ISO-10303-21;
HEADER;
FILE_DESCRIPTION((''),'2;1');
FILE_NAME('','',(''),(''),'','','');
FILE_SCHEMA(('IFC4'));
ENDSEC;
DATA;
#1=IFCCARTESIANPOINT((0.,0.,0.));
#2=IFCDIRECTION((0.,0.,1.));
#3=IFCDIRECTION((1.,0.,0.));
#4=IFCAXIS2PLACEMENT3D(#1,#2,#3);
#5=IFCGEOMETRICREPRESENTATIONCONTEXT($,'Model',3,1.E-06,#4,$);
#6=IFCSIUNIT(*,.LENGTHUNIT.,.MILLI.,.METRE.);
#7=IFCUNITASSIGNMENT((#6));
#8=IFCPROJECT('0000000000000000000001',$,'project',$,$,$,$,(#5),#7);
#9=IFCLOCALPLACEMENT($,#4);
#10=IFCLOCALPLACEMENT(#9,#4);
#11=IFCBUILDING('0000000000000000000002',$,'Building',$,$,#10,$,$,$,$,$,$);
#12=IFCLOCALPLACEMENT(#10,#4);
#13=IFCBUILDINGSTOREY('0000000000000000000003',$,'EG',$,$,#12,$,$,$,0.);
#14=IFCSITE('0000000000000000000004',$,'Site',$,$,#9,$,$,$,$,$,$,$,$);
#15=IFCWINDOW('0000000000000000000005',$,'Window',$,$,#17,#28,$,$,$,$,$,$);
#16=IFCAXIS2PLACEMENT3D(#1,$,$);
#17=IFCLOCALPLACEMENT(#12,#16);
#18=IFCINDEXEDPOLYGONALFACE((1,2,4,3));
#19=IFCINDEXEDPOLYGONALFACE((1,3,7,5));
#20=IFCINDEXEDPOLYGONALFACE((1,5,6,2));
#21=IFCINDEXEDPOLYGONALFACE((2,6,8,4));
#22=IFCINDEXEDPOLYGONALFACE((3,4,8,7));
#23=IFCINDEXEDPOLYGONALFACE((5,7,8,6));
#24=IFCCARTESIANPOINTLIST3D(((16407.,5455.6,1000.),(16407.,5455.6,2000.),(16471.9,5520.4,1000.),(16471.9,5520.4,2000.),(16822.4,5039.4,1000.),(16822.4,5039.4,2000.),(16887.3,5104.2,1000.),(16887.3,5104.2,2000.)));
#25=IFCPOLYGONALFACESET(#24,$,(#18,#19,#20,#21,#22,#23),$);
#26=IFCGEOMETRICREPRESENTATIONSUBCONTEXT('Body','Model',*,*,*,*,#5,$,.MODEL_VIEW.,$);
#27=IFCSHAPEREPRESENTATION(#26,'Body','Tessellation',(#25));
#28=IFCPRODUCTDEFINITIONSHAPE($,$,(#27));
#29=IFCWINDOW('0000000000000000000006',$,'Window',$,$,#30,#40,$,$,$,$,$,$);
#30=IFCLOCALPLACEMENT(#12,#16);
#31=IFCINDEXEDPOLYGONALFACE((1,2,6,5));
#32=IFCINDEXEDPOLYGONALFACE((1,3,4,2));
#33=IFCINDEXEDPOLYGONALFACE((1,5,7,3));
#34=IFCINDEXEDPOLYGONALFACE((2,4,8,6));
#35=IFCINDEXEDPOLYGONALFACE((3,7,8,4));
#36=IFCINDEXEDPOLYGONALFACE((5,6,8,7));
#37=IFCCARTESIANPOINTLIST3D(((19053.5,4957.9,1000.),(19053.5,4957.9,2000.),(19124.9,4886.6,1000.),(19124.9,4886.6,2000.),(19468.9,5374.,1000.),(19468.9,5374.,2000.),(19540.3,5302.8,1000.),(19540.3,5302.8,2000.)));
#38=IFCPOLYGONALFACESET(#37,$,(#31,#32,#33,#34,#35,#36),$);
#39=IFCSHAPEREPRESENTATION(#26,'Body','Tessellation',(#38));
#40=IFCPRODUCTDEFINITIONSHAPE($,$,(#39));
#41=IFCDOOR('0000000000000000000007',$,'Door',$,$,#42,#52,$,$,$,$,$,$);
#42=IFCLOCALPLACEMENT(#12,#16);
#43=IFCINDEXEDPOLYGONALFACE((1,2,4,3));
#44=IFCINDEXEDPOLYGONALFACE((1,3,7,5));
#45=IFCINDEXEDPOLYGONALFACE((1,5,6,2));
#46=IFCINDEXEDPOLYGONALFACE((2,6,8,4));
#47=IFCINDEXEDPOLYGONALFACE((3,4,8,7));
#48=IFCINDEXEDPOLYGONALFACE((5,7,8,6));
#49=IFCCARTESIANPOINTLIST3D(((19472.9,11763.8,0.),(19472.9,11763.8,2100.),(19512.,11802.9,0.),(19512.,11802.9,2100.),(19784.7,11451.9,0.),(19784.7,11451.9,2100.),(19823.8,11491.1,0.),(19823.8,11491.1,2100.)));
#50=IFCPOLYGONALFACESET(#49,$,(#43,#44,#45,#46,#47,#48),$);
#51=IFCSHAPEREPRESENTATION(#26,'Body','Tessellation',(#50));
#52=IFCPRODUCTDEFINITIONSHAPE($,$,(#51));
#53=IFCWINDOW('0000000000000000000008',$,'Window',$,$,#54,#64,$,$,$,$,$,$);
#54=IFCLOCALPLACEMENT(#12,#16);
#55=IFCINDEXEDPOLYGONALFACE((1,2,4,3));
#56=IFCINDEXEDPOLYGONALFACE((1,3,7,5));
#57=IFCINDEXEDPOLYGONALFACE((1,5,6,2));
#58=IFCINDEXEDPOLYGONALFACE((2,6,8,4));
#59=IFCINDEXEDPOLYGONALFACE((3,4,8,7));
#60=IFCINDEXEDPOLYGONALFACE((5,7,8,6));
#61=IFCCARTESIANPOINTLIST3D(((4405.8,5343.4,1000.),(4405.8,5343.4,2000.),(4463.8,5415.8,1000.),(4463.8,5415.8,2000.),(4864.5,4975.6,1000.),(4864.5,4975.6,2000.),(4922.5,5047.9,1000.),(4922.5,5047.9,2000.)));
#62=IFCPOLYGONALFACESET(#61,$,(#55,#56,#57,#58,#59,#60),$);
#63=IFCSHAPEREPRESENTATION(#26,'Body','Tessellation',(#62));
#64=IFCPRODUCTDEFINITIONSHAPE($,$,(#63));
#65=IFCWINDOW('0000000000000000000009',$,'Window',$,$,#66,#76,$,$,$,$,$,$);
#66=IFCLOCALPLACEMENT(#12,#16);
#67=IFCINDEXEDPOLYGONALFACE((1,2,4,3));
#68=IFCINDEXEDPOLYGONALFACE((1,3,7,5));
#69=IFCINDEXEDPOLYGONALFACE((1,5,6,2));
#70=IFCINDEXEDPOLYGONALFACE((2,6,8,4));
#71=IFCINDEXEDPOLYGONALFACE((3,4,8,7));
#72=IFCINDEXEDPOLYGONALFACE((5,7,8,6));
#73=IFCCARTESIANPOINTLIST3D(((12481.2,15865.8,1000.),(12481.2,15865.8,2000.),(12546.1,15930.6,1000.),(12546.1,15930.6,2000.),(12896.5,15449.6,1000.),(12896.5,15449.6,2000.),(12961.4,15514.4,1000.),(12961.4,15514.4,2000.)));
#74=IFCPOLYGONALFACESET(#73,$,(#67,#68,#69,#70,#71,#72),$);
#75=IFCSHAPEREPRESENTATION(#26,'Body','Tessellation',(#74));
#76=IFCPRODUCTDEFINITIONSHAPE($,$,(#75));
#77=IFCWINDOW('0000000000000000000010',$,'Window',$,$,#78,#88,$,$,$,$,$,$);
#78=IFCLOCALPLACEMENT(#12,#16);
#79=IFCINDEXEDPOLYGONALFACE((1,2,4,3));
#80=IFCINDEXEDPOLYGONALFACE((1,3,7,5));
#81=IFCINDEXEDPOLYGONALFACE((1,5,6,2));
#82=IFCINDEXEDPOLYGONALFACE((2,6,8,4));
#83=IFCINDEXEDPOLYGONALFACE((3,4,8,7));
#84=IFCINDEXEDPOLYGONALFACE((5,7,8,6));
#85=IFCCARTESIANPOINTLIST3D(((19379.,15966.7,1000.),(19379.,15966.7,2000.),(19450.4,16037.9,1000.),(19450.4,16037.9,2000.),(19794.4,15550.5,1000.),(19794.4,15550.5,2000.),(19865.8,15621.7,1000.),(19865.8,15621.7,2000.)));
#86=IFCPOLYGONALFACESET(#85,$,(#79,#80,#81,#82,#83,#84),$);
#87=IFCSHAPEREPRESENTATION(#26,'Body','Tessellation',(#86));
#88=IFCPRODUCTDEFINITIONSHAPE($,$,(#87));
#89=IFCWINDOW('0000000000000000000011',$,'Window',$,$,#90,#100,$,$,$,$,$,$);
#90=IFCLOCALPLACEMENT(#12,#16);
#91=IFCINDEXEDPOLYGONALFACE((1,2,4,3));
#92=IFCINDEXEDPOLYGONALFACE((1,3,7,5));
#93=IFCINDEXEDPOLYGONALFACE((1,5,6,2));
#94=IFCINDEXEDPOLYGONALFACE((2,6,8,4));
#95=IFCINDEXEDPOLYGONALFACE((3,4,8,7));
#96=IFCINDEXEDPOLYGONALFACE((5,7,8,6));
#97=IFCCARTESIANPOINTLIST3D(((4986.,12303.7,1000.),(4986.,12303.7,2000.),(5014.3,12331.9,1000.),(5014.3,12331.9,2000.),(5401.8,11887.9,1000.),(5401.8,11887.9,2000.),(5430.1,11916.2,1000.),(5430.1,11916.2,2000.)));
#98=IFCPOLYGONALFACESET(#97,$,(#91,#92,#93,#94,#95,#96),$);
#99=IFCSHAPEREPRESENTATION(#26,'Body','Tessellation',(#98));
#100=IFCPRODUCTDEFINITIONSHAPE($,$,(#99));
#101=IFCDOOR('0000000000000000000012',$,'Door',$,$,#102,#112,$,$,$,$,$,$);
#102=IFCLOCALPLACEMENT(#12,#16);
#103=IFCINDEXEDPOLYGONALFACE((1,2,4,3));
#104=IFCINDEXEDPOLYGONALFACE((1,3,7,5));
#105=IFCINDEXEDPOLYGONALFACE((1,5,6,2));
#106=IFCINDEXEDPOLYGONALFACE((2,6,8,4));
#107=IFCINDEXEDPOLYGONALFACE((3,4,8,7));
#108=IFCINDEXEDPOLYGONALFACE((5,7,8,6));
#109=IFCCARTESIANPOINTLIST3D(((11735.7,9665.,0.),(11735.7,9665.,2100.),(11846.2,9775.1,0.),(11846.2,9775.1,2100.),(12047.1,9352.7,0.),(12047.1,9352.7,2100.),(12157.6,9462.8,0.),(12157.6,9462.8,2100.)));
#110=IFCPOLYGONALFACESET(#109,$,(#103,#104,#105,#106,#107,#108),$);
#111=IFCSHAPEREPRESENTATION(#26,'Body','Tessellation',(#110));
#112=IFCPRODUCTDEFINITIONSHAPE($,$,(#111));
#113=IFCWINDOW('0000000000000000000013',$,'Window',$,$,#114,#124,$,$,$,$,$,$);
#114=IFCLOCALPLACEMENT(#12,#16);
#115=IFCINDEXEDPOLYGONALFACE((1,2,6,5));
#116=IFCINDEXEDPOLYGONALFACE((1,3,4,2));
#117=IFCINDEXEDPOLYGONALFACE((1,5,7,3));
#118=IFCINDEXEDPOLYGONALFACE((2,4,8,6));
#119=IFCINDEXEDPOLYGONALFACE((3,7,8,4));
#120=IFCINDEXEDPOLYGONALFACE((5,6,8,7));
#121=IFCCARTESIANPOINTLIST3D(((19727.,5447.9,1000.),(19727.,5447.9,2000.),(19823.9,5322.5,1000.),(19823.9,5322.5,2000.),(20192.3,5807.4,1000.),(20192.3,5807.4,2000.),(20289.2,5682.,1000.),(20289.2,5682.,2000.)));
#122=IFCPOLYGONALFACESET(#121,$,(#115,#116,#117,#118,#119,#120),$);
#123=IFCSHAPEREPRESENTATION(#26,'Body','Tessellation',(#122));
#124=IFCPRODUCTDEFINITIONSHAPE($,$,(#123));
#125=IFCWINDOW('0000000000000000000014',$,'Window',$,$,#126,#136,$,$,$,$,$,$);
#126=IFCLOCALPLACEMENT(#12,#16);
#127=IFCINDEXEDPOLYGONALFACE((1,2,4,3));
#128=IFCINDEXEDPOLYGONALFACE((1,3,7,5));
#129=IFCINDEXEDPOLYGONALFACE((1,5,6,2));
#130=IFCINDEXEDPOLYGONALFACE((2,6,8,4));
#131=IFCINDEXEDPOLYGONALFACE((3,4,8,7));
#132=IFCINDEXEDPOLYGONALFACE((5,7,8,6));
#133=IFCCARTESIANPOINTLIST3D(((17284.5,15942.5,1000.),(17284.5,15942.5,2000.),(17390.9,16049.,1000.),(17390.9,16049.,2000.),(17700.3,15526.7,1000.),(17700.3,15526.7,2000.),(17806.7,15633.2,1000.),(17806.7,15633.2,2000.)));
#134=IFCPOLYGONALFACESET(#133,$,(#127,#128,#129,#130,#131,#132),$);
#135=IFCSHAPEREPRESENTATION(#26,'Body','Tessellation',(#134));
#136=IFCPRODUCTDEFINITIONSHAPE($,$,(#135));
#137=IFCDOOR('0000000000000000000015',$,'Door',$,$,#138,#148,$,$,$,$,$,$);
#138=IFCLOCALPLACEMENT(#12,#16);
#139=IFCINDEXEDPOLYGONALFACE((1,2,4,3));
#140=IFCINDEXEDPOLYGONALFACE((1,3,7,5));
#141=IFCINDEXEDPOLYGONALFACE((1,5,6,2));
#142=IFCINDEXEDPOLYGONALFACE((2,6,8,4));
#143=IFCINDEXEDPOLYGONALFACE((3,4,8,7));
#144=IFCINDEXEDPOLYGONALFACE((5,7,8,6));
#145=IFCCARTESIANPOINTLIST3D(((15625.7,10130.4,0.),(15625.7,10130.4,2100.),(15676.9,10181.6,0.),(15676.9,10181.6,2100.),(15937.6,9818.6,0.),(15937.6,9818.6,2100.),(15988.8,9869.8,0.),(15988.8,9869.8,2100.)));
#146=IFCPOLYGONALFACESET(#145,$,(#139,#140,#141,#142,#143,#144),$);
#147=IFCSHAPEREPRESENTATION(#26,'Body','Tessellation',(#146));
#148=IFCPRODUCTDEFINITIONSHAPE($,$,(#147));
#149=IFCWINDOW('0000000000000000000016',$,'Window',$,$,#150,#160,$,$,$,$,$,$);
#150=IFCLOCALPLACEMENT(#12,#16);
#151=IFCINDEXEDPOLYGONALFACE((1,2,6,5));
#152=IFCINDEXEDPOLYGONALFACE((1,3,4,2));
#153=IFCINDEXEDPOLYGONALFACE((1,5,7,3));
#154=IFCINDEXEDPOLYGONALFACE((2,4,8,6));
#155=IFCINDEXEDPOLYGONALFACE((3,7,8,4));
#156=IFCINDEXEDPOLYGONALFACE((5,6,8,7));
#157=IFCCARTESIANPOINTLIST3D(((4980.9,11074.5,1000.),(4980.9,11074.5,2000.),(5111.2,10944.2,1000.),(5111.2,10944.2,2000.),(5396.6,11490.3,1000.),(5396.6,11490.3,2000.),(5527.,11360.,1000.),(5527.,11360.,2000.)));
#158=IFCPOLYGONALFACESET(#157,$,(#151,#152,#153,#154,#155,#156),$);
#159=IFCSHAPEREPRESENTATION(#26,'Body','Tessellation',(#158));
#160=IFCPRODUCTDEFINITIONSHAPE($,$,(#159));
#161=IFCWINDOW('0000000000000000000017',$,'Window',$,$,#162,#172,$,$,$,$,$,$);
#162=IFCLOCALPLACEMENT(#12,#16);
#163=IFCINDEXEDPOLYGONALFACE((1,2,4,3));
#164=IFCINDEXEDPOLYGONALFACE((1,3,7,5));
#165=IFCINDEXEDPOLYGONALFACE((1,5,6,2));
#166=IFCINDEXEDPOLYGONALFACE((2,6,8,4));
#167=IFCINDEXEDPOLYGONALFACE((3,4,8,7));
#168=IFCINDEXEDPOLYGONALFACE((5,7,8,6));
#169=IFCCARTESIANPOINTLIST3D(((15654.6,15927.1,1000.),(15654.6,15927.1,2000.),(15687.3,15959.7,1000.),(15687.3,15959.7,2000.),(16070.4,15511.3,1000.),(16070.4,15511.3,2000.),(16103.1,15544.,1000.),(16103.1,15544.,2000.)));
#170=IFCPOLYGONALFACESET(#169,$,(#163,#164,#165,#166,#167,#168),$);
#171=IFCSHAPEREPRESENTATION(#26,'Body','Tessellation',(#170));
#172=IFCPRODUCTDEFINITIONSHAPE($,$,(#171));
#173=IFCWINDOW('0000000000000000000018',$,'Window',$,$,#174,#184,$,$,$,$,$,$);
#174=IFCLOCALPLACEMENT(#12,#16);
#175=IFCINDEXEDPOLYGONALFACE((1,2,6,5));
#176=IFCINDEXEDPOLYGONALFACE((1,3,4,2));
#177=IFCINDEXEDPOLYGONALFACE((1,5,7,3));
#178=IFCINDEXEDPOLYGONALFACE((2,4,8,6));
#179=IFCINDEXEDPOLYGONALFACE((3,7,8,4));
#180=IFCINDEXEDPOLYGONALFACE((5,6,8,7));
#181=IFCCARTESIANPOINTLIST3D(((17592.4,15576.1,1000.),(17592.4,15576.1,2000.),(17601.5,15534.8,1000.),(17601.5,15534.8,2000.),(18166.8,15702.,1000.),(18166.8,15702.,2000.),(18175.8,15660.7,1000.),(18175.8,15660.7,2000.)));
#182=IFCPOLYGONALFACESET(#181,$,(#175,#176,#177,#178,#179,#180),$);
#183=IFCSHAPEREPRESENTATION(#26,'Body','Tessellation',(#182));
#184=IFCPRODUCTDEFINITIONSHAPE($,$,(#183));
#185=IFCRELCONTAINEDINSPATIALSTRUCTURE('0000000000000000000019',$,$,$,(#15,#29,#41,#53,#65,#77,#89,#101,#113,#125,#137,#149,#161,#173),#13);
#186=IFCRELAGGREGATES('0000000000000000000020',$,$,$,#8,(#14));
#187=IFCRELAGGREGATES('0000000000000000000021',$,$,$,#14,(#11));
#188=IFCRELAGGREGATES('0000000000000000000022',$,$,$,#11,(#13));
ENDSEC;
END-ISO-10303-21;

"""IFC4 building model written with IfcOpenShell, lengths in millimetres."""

from ifc_helpers import new_model, si_unit, frame, origin_with_axes, place, context, subcontext, project, spatial, rectangle, extrude, element, save


model = new_model("IFC4")

# Units and contexts
model_context = context("Model", 3, precision=1e-06, world=origin_with_axes())
body_context = subcontext(model_context, "Body", "Model", "MODEL_VIEW")
ifc_project = project(units=[si_unit("LENGTHUNIT", "METRE", prefix="MILLI")], contexts=[model_context])

# Site, building, storey
site_placement = place(None, origin_with_axes())
site = spatial("IfcSite", under=ifc_project, at=site_placement, Name="Site")
building_placement = place(site_placement, origin_with_axes())
building = spatial("IfcBuilding", under=site, at=building_placement, Name="Building")
storey_placement = place(building_placement, origin_with_axes())
storey = spatial("IfcBuildingStorey", under=building, at=storey_placement, Name="EG", Elevation=0.0)

# Windows
window_1_placement = place(storey_placement, origin_with_axes())
element("IfcWindow", 1, at=window_1_placement, inside=storey, Name="Window", context=body_context, shape_type="SweptSolid", body=[
    extrude(rectangle(XDim=588.0, YDim=91.7), frame((16647.2, 5279.9, 1000.0), z_axis=(0.0, 0.0, 1.0), x_axis=(-0.706427, 0.707786, 0.0)), (0.0, 0.0, 1.0), 1000.0),
])
window_2_placement = place(storey_placement, origin_with_axes())
element("IfcWindow", 2, at=window_2_placement, inside=storey, Name="Window", context=body_context, shape_type="SweptSolid", body=[
    extrude(rectangle(XDim=588.0, YDim=100.8), frame((19296.9, 5130.3, 1000.0), z_axis=(0.0, 0.0, 1.0), x_axis=(-0.706489, -0.707724, 0.0)), (0.0, 0.0, 1.0), 1000.0),
])

# Door
door_1_placement = place(storey_placement, origin_with_axes())
element("IfcDoor", 3, at=door_1_placement, inside=storey, Name="Door", context=body_context, shape_type="SweptSolid", body=[
    extrude(rectangle(XDim=441.0, YDim=55.3), frame((19648.4, 11627.4, 0.0), z_axis=(0.0, 0.0, 1.0), x_axis=(-0.707107, 0.707107, 0.0)), (0.0, 0.0, 1.0), 2100.0),
])

# Windows
window_3_placement = place(storey_placement, origin_with_axes())
element("IfcWindow", 4, at=window_3_placement, inside=storey, Name="Window", context=body_context, shape_type="SweptSolid", body=[
    extrude(rectangle(XDim=588.0, YDim=92.8), frame((4664.1, 5195.7, 1000.0), z_axis=(0.0, 0.0, 1.0), x_axis=(0.780136, -0.625609, 0.0)), (0.0, 0.0, 1.0), 1000.0),
])
window_4_placement = place(storey_placement, origin_with_axes())
element("IfcWindow", 5, at=window_4_placement, inside=storey, Name="Window", context=body_context, shape_type="SweptSolid", body=[
    extrude(rectangle(XDim=588.0, YDim=91.7), frame((12721.3, 15690.1, 1000.0), z_axis=(0.0, 0.0, 1.0), x_axis=(0.706427, -0.707786, 0.0)), (0.0, 0.0, 1.0), 1000.0),
])
window_5_placement = place(storey_placement, origin_with_axes())
element("IfcWindow", 6, at=window_5_placement, inside=storey, Name="Window", context=body_context, shape_type="SweptSolid", body=[
    extrude(rectangle(XDim=588.0, YDim=100.8), frame((19622.4, 15794.2, 1000.0), z_axis=(0.0, 0.0, 1.0), x_axis=(-0.706489, 0.707724, 0.0)), (0.0, 0.0, 1.0), 1000.0),
])
window_6_placement = place(storey_placement, origin_with_axes())
element("IfcWindow", 7, at=window_6_placement, inside=storey, Name="Window", context=body_context, shape_type="SweptSolid", body=[
    extrude(rectangle(XDim=588.0, YDim=40.0), frame((5208.0, 12109.9, 1000.0), z_axis=(0.0, 0.0, 1.0), x_axis=(0.707107, -0.707107, 0.0)), (0.0, 0.0, 1.0), 1000.0),
])

# Door
door_2_placement = place(storey_placement, origin_with_axes())
element("IfcDoor", 8, at=door_2_placement, inside=storey, Name="Door", context=body_context, shape_type="SweptSolid", body=[
    extrude(rectangle(XDim=441.0, YDim=156.0), frame((11946.6, 9563.9, 0.0), z_axis=(0.0, 0.0, 1.0), x_axis=(0.705975, -0.708237, 0.0)), (0.0, 0.0, 1.0), 2100.0),
])

# Windows
window_7_placement = place(storey_placement, origin_with_axes())
element("IfcWindow", 9, at=window_7_placement, inside=storey, Name="Window", context=body_context, shape_type="SweptSolid", body=[
    extrude(rectangle(XDim=588.0, YDim=158.5), frame((20008.1, 5565.0, 1000.0), z_axis=(0.0, 0.0, 1.0), x_axis=(-0.791285, -0.611448, 0.0)), (0.0, 0.0, 1.0), 1000.0),
])
window_8_placement = place(storey_placement, origin_with_axes())
element("IfcWindow", 10, at=window_8_placement, inside=storey, Name="Window", context=body_context, shape_type="SweptSolid", body=[
    extrude(rectangle(XDim=588.0, YDim=150.5), frame((17545.6, 15787.9, 1000.0), z_axis=(0.0, 0.0, 1.0), x_axis=(-0.707107, 0.707107, 0.0)), (0.0, 0.0, 1.0), 1000.0),
])

# Door
door_3_placement = place(storey_placement, origin_with_axes())
element("IfcDoor", 11, at=door_3_placement, inside=storey, Name="Door", context=body_context, shape_type="SweptSolid", body=[
    extrude(rectangle(XDim=441.0, YDim=72.4), frame((15807.3, 10000.1, 0.0), z_axis=(0.0, 0.0, 1.0), x_axis=(-0.707107, 0.707107, 0.0)), (0.0, 0.0, 1.0), 2100.0),
])

# Windows
window_9_placement = place(storey_placement, origin_with_axes())
element("IfcWindow", 12, at=window_9_placement, inside=storey, Name="Window", context=body_context, shape_type="SweptSolid", body=[
    extrude(rectangle(XDim=588.0, YDim=184.3), frame((5253.9, 11217.3, 1000.0), z_axis=(0.0, 0.0, 1.0), x_axis=(-0.707107, -0.707107, 0.0)), (0.0, 0.0, 1.0), 1000.0),
])
window_10_placement = place(storey_placement, origin_with_axes())
element("IfcWindow", 13, at=window_10_placement, inside=storey, Name="Window", context=body_context, shape_type="SweptSolid", body=[
    extrude(rectangle(XDim=588.0, YDim=46.2), frame((15878.9, 15735.5, 1000.0), z_axis=(0.0, 0.0, 1.0), x_axis=(-0.707107, 0.707107, 0.0)), (0.0, 0.0, 1.0), 1000.0),
])
window_11_placement = place(storey_placement, origin_with_axes())
element("IfcWindow", 14, at=window_11_placement, inside=storey, Name="Window", context=body_context, shape_type="SweptSolid", body=[
    extrude(rectangle(XDim=588.0, YDim=42.3), frame((17884.1, 15618.4, 1000.0), z_axis=(0.0, 0.0, 1.0), x_axis=(0.976807, 0.21412, 0.0)), (0.0, 0.0, 1.0), 1000.0),
])

save(model, "model.ifc")
